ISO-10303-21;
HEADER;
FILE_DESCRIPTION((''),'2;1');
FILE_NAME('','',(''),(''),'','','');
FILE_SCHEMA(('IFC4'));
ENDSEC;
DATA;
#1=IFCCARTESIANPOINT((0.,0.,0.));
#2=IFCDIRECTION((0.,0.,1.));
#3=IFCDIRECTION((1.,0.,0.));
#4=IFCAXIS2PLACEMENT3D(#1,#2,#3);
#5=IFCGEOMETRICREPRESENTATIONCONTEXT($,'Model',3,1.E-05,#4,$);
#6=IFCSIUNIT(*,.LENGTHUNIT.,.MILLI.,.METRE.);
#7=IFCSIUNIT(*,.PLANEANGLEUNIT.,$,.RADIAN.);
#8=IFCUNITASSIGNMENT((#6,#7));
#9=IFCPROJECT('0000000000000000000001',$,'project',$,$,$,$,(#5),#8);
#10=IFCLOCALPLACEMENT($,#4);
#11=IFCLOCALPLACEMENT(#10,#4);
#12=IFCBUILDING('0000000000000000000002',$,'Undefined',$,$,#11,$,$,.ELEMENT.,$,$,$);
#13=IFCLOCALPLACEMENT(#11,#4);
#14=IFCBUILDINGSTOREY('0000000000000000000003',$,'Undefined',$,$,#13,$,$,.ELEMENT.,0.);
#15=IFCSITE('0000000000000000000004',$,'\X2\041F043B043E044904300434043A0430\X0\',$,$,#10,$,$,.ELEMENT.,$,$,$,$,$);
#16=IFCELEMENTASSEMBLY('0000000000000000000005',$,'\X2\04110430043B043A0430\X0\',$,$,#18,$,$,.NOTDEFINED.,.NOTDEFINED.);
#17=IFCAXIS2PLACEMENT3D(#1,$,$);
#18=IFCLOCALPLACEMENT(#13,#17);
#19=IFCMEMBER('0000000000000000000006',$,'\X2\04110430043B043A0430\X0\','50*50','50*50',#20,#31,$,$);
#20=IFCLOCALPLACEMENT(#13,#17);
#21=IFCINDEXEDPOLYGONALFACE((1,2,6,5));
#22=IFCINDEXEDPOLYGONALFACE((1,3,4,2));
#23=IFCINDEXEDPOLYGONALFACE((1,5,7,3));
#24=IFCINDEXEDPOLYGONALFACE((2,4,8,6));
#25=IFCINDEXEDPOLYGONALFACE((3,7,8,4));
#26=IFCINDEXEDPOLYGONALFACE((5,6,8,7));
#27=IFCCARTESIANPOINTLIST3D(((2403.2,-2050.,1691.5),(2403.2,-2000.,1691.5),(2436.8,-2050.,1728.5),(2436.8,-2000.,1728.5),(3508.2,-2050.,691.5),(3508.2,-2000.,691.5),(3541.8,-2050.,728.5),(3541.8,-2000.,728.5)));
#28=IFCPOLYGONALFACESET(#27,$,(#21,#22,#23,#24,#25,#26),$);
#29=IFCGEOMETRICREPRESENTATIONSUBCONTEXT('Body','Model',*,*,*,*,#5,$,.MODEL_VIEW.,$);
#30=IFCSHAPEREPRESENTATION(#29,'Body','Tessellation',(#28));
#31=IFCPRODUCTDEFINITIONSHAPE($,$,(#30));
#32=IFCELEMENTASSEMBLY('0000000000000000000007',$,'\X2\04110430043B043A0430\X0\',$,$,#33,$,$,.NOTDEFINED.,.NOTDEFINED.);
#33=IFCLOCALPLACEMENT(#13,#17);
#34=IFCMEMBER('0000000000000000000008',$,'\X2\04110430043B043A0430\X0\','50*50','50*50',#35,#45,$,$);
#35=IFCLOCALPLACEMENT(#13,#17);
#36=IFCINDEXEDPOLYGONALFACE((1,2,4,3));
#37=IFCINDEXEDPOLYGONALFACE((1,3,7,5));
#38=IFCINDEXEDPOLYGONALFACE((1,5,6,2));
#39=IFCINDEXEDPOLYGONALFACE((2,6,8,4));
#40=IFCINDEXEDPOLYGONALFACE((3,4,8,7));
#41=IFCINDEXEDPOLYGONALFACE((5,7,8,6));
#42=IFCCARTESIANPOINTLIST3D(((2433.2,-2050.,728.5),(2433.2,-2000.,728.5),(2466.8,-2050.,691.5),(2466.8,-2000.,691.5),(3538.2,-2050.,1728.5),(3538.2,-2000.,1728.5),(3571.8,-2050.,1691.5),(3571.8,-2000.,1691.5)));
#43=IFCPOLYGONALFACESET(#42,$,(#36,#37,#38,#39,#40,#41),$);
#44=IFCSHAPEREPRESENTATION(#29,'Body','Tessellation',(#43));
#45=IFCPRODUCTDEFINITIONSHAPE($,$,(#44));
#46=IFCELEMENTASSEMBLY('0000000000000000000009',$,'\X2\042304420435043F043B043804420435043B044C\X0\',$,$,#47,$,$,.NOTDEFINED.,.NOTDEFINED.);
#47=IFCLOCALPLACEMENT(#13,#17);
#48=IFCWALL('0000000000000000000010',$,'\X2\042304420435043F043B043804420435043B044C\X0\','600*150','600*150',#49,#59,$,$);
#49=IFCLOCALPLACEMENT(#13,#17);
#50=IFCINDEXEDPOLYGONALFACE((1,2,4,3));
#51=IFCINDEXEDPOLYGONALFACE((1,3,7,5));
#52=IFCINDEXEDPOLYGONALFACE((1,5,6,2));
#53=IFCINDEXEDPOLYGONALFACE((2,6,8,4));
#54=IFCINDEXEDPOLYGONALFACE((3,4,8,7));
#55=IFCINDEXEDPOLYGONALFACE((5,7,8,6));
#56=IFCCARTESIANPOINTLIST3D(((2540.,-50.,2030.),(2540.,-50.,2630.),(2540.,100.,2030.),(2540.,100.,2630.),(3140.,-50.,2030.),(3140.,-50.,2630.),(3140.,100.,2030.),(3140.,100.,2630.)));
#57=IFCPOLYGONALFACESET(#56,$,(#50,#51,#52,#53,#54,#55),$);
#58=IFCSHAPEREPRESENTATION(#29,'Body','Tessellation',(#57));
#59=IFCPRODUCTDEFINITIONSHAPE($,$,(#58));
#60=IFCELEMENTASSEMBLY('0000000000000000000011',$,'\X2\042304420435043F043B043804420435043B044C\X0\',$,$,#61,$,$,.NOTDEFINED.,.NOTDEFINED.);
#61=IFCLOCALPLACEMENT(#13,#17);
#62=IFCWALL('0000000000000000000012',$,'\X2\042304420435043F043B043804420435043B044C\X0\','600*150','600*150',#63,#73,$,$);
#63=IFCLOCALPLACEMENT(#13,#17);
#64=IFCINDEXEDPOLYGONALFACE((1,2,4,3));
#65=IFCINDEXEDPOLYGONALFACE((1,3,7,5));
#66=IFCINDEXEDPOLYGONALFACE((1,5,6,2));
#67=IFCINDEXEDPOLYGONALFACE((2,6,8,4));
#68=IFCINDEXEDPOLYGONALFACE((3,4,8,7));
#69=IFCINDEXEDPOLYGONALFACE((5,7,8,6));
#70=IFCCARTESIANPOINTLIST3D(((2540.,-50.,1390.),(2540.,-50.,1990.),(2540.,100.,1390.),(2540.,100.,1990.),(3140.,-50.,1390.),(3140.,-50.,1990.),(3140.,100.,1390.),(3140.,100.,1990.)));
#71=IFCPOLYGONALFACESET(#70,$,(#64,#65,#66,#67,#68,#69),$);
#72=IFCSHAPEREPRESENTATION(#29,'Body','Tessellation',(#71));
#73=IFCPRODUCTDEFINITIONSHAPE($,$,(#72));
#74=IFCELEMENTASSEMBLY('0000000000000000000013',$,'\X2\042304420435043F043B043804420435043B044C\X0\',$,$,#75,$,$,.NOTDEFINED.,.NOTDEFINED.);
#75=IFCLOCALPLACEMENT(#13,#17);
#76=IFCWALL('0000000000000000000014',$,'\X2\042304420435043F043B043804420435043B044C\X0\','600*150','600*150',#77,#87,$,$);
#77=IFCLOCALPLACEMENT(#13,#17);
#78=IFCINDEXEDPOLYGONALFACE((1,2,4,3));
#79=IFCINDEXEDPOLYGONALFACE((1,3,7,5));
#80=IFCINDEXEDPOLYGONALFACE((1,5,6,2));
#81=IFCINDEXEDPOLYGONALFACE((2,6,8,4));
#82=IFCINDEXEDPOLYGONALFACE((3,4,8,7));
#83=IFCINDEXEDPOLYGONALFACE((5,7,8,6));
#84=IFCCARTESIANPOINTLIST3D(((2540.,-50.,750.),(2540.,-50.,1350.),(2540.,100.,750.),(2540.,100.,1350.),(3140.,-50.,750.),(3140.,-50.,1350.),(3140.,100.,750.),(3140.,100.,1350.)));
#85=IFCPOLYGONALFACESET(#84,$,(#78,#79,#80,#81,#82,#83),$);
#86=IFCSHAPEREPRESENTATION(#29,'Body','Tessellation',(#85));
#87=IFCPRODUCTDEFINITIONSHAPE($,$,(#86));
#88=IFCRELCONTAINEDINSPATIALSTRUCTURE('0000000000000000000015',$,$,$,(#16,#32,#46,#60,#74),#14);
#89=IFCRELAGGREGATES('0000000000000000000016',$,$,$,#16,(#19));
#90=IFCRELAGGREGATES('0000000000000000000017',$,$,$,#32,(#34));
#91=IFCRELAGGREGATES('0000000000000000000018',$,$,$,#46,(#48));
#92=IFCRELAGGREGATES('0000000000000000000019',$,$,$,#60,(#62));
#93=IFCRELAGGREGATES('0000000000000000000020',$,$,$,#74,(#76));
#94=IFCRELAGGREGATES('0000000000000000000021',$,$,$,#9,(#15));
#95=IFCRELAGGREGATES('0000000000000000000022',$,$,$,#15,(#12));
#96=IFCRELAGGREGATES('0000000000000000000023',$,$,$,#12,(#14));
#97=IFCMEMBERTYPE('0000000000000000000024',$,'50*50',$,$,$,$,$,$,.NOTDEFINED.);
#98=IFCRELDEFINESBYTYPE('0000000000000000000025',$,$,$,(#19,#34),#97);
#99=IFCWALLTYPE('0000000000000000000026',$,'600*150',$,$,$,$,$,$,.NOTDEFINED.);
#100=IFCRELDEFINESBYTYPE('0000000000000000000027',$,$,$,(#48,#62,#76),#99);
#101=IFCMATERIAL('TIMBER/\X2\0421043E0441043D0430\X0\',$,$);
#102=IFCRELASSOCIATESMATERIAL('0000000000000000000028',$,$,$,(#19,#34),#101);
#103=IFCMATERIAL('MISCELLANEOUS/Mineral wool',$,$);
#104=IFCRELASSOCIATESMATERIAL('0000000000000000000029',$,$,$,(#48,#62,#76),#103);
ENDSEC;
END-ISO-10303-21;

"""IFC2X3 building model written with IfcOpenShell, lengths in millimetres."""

from ifc_helpers import new_model, si_unit, frame, frame_2d, origin_with_axes, origin_2d_with_axis, place, context, subcontext, project, spatial, rectangle, extrude, material, type_object, element, aggregate, save


model = new_model("IFC2X3")

# Units and contexts
model_context = context("Model", 3, precision=1e-05, world=origin_with_axes())
body_context = subcontext(model_context, "Body", "Model", "MODEL_VIEW")
ifc_project = project(units=[si_unit("LENGTHUNIT", "METRE", prefix="MILLI"), si_unit("PLANEANGLEUNIT", "RADIAN")], contexts=[model_context])

# Site, building, storey
site_placement = place(None, origin_with_axes())
site = spatial("IfcSite", under=ifc_project, at=site_placement, Name="Площадка", CompositionType="ELEMENT")
building_placement = place(site_placement, origin_with_axes())
building = spatial("IfcBuilding", under=site, at=building_placement, Name="Undefined", CompositionType="ELEMENT")
storey_placement = place(building_placement, origin_with_axes())
storey = spatial("IfcBuildingStorey", under=building, at=storey_placement, Name="Undefined", CompositionType="ELEMENT", Elevation=0.0)

# Shared definitions
ifc_material_1 = material(Name="TIMBER/Сосна")

# Element assemblies, members
assembly_1_placement = place(storey_placement, origin_with_axes())
assembly_1 = element("IfcElementAssembly", 1, at=assembly_1_placement, inside=storey, Name="Балка", AssemblyPlace="NOTDEFINED", PredefinedType="NOTDEFINED")
member_type_1 = type_object("IfcMemberType", Name="50*50", PredefinedType="NOTDEFINED")
member_1_placement = place(assembly_1_placement, frame((3525.0, -2025.0, 710.0), z_axis=(0.0, 1.0, 0.0), x_axis=(-0.741456, 0.0, 0.671001)))
member_1 = element("IfcMember", 2, at=member_1_placement, type_object=member_type_1, material=ifc_material_1, Name="Балка", Description="50*50", ObjectType="50*50", context=body_context, shape_type="SweptSolid", body=[
    extrude(rectangle(XDim=50.0, YDim=50.0, at=origin_2d_with_axis()), frame((1490.3, 0.0, 0.0), z_axis=(-1.0, 0.0, 0.0), x_axis=(0.0, -1.0, 0.0)), (0.0, 0.0, 1.0), 1490.3),
])
aggregate(assembly_1, [member_1])
assembly_2_placement = place(storey_placement, origin_with_axes())
assembly_2 = element("IfcElementAssembly", 3, at=assembly_2_placement, inside=storey, Name="Балка", AssemblyPlace="NOTDEFINED", PredefinedType="NOTDEFINED")
member_2_placement = place(assembly_2_placement, frame((2450.0, -2025.0, 710.0), z_axis=(0.0, 1.0, 0.0), x_axis=(0.741456, 0.0, 0.671001)))
member_2 = element("IfcMember", 4, at=member_2_placement, type_object=member_type_1, material=ifc_material_1, Name="Балка", Description="50*50", ObjectType="50*50", context=body_context, shape_type="SweptSolid", body=[
    extrude(rectangle(XDim=50.0, YDim=50.0, at=origin_2d_with_axis()), frame((1490.3, 0.0, 0.0), z_axis=(-1.0, 0.0, 0.0), x_axis=(0.0, -1.0, 0.0)), (0.0, 0.0, 1.0), 1490.3),
])
aggregate(assembly_2, [member_2])

# Element assemblies, walls
assembly_3_placement = place(storey_placement, origin_with_axes())
assembly_3 = element("IfcElementAssembly", 5, at=assembly_3_placement, inside=storey, Name="Утеплитель", AssemblyPlace="NOTDEFINED", PredefinedType="NOTDEFINED")
ifc_material_2 = material(Name="MISCELLANEOUS/Mineral wool")
wall_type = type_object("IfcWallType", Name="600*150", PredefinedType="NOTDEFINED")
wall_1_placement = place(assembly_3_placement, frame((2540.0, 25.0, 2030.0), z_axis=(0.0, 0.0, 1.0), x_axis=(1.0, 0.0, 0.0)))
wall_1 = element("IfcWall", 6, at=wall_1_placement, type_object=wall_type, material=ifc_material_2, Name="Утеплитель", Description="600*150", ObjectType="600*150", context=body_context, shape_type="SweptSolid", body=[
    extrude(rectangle(XDim=600.0, YDim=150.0, at=frame_2d((0.0, 300.0), x_axis=(0.0, -1.0))), frame((0.0, 0.0, 0.0), z_axis=(0.0, 0.0, 1.0), x_axis=(0.0, -1.0, 0.0)), (0.0, 0.0, 1.0), 600.0),
])
aggregate(assembly_3, [wall_1])
assembly_4_placement = place(storey_placement, origin_with_axes())
assembly_4 = element("IfcElementAssembly", 7, at=assembly_4_placement, inside=storey, Name="Утеплитель", AssemblyPlace="NOTDEFINED", PredefinedType="NOTDEFINED")
wall_2_placement = place(assembly_4_placement, frame((2540.0, 25.0, 1390.0), z_axis=(0.0, 0.0, 1.0), x_axis=(1.0, 0.0, 0.0)))
wall_2 = element("IfcWall", 8, at=wall_2_placement, type_object=wall_type, material=ifc_material_2, Name="Утеплитель", Description="600*150", ObjectType="600*150", context=body_context, shape_type="SweptSolid", body=[
    extrude(rectangle(XDim=600.0, YDim=150.0, at=frame_2d((0.0, 300.0), x_axis=(0.0, -1.0))), frame((0.0, 0.0, 0.0), z_axis=(0.0, 0.0, 1.0), x_axis=(0.0, -1.0, 0.0)), (0.0, 0.0, 1.0), 600.0),
])
aggregate(assembly_4, [wall_2])
assembly_5_placement = place(storey_placement, origin_with_axes())
assembly_5 = element("IfcElementAssembly", 9, at=assembly_5_placement, inside=storey, Name="Утеплитель", AssemblyPlace="NOTDEFINED", PredefinedType="NOTDEFINED")
wall_3_placement = place(assembly_5_placement, frame((2540.0, 25.0, 750.0), z_axis=(0.0, 0.0, 1.0), x_axis=(1.0, 0.0, 0.0)))
wall_3 = element("IfcWall", 10, at=wall_3_placement, type_object=wall_type, material=ifc_material_2, Name="Утеплитель", Description="600*150", ObjectType="600*150", context=body_context, shape_type="SweptSolid", body=[
    extrude(rectangle(XDim=600.0, YDim=150.0, at=frame_2d((0.0, 300.0), x_axis=(0.0, -1.0))), frame((0.0, 0.0, 0.0), z_axis=(0.0, 0.0, 1.0), x_axis=(0.0, -1.0, 0.0)), (0.0, 0.0, 1.0), 600.0),
])
aggregate(assembly_5, [wall_3])

save(model, "model.ifc")
